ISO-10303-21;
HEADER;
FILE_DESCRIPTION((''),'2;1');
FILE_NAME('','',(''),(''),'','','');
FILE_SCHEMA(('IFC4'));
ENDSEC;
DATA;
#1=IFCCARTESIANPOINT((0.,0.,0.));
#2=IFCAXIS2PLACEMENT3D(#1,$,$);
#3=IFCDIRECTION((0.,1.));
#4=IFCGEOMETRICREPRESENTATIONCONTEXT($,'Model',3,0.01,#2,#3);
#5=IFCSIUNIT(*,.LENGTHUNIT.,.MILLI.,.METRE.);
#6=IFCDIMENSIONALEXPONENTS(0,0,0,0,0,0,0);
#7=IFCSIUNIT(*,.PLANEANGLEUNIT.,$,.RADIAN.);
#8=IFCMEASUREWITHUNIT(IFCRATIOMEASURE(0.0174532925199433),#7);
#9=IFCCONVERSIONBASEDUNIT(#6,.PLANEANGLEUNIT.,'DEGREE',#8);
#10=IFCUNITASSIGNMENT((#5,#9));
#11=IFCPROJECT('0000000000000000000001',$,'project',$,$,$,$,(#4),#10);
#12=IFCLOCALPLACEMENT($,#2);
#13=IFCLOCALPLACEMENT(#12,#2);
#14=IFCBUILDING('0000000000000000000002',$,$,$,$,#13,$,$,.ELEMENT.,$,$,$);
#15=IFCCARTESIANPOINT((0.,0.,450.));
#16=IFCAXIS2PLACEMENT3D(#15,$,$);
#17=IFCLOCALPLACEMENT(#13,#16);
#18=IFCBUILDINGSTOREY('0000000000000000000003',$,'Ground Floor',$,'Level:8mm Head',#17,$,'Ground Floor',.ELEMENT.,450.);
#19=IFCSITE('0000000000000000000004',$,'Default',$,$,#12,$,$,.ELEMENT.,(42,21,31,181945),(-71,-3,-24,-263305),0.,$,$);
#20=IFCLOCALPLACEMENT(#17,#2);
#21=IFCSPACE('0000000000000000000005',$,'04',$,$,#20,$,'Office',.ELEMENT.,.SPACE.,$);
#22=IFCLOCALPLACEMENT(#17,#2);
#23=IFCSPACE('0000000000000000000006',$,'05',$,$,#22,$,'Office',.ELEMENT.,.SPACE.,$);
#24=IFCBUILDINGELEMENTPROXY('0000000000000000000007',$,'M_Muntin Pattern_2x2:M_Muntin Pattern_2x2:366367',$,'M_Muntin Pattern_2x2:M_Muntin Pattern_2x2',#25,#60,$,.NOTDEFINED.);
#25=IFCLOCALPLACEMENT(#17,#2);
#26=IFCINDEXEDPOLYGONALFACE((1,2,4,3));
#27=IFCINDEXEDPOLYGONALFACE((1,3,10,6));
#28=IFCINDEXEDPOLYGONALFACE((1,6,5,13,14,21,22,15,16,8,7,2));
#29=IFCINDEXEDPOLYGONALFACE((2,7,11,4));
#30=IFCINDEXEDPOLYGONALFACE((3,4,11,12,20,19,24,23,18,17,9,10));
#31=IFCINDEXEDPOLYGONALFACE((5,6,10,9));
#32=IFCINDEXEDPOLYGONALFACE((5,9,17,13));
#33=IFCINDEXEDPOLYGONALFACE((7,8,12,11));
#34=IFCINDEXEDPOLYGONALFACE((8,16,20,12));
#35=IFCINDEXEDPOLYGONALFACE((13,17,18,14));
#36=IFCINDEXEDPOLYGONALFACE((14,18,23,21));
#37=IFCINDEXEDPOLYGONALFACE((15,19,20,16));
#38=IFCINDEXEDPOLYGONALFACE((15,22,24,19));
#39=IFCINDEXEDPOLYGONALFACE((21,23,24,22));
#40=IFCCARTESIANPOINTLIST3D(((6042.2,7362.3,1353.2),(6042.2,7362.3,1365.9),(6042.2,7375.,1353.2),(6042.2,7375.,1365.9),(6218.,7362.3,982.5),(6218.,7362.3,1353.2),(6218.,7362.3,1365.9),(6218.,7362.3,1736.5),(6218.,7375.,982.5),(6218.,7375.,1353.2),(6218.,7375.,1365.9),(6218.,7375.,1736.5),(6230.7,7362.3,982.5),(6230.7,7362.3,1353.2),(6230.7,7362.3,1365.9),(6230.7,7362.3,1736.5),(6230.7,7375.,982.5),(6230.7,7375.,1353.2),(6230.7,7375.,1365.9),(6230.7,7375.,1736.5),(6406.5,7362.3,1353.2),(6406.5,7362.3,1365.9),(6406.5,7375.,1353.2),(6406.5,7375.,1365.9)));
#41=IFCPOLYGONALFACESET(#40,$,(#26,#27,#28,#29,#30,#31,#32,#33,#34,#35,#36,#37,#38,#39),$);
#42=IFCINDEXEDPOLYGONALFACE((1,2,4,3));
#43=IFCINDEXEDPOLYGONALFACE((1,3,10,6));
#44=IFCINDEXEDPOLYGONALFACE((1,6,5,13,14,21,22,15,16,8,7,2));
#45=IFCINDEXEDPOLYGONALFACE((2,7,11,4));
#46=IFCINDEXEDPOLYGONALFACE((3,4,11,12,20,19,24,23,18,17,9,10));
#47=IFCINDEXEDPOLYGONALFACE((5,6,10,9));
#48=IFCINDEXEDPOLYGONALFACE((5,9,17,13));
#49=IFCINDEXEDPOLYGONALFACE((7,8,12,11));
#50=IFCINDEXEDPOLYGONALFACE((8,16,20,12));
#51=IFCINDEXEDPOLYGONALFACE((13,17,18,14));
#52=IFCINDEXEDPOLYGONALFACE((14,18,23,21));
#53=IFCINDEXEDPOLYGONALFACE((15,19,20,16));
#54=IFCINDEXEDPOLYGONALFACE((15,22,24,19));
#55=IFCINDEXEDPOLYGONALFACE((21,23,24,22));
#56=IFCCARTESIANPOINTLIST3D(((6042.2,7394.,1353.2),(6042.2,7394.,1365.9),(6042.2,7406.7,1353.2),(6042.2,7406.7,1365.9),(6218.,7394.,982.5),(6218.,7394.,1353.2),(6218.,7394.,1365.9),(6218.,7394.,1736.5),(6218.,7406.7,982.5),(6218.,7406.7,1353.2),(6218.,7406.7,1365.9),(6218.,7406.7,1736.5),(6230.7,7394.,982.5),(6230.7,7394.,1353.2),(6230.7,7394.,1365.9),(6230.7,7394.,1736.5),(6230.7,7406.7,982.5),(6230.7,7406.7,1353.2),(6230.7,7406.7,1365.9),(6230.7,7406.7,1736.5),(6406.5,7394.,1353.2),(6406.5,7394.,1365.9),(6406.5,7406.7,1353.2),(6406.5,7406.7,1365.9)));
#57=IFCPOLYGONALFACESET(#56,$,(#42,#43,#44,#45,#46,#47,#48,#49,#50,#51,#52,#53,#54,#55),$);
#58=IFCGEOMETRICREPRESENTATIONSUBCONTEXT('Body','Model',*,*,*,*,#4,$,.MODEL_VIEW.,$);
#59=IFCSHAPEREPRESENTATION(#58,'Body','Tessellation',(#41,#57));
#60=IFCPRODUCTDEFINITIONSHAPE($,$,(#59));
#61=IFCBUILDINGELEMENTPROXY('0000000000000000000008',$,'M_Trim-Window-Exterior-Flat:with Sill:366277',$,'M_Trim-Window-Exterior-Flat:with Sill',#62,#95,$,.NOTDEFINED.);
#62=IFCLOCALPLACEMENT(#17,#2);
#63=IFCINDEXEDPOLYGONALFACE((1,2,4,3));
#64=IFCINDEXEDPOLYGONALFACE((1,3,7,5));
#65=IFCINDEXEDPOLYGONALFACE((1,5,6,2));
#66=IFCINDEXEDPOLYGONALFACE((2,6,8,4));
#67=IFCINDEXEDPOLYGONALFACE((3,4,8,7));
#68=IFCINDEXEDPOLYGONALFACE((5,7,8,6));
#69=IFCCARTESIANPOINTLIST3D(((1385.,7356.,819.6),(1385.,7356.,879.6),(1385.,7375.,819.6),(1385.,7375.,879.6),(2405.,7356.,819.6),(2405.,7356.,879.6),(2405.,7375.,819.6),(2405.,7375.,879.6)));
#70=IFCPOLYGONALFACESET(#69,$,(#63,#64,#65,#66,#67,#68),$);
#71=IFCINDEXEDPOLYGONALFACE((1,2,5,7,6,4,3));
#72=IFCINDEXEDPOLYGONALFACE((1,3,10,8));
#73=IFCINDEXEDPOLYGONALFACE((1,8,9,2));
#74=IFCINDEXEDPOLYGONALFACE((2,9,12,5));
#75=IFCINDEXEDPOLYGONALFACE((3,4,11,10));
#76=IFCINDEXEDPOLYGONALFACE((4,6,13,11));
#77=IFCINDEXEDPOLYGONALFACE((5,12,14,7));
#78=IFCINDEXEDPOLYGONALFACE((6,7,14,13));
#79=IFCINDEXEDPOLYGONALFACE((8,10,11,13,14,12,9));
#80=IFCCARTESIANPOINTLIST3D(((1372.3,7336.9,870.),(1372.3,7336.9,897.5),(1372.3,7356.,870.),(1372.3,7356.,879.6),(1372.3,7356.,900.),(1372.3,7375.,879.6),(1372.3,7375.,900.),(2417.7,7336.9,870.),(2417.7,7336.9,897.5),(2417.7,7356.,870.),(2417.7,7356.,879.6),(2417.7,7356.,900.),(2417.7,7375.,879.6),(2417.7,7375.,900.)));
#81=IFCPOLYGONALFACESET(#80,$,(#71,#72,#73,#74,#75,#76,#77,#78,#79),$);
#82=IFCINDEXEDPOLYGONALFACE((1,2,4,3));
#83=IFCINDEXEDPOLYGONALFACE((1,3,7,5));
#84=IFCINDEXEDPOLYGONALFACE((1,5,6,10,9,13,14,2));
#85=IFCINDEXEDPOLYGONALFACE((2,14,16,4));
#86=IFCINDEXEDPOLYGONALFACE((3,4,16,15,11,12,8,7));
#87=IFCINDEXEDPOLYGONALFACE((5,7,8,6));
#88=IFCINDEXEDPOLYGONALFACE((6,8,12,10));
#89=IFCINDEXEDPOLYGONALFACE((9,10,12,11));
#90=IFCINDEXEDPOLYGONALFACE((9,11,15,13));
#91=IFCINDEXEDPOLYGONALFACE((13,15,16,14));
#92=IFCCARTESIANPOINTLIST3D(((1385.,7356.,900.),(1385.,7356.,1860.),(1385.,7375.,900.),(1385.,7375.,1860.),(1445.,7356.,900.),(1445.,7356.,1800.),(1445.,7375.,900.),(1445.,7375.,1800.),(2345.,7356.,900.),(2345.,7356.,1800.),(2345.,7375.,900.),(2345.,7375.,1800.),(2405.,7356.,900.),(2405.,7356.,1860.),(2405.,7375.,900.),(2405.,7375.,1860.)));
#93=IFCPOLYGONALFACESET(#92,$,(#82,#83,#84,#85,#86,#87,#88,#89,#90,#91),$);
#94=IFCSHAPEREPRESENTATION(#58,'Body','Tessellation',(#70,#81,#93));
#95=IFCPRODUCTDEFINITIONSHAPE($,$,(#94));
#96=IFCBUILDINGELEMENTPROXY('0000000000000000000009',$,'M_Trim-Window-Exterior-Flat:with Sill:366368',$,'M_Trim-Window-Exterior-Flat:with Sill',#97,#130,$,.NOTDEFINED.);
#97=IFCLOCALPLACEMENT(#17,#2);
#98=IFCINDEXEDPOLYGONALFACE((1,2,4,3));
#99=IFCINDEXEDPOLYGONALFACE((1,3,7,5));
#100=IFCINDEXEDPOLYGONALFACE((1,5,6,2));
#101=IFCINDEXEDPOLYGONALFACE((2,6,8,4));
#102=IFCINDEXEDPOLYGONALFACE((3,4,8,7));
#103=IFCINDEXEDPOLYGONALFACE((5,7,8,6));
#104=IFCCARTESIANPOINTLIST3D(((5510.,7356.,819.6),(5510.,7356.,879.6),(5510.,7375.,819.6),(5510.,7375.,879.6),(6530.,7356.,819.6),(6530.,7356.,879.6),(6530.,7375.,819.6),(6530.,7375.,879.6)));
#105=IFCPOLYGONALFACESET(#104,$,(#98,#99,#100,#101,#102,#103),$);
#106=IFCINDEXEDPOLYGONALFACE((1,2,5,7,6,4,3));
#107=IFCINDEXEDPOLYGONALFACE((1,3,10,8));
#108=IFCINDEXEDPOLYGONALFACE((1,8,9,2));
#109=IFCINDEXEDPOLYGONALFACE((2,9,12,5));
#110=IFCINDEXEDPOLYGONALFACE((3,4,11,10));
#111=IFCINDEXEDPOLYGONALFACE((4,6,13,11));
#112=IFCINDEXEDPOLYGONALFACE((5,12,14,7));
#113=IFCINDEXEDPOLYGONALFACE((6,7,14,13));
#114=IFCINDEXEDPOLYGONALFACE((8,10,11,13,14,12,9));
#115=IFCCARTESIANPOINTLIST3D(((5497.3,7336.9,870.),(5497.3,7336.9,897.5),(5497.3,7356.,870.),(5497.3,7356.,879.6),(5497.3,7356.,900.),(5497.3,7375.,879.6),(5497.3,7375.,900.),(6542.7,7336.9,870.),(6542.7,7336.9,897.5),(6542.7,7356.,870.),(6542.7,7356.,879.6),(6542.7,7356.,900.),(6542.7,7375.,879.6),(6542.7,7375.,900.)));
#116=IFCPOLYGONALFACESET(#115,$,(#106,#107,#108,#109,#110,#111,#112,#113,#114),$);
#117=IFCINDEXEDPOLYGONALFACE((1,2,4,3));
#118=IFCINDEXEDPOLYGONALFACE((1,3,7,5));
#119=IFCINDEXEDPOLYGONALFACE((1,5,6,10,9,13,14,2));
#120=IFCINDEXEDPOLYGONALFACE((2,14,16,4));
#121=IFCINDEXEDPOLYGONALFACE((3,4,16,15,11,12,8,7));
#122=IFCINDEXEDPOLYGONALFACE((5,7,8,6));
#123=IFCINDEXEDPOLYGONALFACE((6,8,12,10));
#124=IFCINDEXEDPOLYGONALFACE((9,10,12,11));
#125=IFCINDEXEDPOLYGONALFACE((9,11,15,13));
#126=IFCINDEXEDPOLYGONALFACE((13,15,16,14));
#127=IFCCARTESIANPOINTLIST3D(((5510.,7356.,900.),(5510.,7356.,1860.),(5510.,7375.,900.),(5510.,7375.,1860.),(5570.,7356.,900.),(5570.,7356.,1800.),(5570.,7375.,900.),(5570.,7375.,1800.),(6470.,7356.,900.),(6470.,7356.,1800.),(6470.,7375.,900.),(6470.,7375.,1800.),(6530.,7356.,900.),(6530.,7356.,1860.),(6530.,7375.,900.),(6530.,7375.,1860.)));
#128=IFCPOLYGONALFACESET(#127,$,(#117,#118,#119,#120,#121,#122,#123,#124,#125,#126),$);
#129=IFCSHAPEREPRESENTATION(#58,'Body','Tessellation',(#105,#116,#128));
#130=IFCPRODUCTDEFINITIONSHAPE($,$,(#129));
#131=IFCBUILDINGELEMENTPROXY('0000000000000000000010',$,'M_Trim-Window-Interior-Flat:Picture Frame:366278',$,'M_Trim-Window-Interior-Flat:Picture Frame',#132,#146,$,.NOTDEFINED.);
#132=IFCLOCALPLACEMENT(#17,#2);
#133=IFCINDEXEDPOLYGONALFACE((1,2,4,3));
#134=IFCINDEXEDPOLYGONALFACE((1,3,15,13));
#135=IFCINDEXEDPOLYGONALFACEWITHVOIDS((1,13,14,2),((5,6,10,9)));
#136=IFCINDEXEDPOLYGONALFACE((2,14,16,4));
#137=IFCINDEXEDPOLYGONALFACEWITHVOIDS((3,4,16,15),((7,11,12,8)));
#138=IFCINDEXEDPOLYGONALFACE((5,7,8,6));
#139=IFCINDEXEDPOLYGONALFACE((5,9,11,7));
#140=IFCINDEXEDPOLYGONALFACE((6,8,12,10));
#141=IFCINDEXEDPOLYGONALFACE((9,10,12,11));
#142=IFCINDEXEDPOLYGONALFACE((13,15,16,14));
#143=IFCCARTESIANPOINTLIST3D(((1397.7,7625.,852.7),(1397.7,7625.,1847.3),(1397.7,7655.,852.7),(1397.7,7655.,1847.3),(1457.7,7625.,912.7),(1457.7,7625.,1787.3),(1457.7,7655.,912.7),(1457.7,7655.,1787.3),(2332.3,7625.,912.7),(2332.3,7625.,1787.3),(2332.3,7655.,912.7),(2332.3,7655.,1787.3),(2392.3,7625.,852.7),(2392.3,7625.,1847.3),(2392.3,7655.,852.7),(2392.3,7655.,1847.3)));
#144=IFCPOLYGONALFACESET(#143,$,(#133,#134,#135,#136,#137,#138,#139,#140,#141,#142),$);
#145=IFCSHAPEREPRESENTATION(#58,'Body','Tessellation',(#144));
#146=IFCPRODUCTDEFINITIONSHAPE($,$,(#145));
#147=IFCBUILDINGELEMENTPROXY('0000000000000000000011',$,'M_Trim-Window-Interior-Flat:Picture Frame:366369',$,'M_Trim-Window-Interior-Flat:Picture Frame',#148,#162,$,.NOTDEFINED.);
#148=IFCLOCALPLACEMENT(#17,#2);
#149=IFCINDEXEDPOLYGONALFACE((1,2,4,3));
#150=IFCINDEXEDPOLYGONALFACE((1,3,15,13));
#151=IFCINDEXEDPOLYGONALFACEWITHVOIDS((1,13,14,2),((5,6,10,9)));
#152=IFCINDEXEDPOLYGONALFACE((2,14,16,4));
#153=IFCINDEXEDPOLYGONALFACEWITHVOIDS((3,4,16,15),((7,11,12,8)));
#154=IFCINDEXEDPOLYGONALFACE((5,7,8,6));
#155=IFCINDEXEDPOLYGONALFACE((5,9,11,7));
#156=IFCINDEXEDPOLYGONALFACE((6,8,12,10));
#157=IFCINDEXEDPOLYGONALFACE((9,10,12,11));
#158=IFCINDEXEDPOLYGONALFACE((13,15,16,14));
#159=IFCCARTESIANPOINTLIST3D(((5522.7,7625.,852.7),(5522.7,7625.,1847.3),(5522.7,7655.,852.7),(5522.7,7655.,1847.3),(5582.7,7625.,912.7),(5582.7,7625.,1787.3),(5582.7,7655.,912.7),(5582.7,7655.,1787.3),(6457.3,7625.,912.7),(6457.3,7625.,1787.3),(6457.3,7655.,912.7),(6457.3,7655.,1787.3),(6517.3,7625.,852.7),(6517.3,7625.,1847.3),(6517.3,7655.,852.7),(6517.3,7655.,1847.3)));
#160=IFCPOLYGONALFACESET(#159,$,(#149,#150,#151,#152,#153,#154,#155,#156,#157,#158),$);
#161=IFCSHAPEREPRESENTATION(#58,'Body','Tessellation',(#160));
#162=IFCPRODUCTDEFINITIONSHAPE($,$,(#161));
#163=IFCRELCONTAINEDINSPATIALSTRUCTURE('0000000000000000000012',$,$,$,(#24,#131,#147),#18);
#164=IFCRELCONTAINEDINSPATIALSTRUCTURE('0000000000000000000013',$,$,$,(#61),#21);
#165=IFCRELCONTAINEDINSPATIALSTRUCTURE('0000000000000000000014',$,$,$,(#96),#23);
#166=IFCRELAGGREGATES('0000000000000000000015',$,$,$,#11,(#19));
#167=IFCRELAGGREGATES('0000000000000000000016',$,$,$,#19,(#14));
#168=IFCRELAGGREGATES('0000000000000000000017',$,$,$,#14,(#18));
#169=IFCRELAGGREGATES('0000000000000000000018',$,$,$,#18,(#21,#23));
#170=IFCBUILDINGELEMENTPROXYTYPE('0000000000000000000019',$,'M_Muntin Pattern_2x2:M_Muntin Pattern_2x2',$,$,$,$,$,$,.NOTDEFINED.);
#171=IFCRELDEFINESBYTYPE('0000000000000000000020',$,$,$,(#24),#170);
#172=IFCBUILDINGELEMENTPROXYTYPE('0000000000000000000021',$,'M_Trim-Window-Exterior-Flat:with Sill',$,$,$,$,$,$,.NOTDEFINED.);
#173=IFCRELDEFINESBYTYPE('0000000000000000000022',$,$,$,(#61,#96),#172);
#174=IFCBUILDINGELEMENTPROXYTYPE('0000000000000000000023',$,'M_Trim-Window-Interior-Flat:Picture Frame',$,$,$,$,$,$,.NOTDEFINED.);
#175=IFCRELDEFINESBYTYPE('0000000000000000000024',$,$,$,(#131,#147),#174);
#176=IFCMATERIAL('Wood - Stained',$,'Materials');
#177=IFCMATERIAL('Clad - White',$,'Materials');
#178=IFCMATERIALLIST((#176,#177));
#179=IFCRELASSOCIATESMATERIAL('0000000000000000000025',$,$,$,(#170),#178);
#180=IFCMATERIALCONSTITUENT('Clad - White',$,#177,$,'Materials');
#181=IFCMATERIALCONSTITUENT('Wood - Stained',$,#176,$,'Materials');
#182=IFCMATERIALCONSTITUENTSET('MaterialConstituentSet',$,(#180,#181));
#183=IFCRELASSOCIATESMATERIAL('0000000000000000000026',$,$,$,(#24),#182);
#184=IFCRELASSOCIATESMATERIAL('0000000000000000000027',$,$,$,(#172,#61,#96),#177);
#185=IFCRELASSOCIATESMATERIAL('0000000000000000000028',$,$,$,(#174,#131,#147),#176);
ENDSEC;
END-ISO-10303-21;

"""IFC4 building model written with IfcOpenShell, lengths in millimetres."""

from ifc_helpers import new_model, entity, si_unit, converted_unit, direction, frame, frame_2d, origin, place, context, subcontext, project, spatial, polyline, rectangle, outline, extrude, source, transform, mapped, material, material_list, constituent, constituent_set, type_object, type_shapes, element, save


model = new_model("IFC4")

# Units and contexts
model_context = context("Model", 3, precision=0.01, world=origin(), true_north=direction((0.0, 1.0)))
body_context = subcontext(model_context, "Body", "Model", "MODEL_VIEW")
ifc_project = project(units=[si_unit("LENGTHUNIT", "METRE", prefix="MILLI"), converted_unit("PLANEANGLEUNIT", "DEGREE", entity("IfcRatioMeasure", 0.0174532925199433), si_unit("PLANEANGLEUNIT", "RADIAN"), dimensions=[0, 0, 0, 0, 0, 0, 0])], contexts=[model_context])

# Site, building, storey
site_placement = place(None, origin())
site = spatial("IfcSite", under=ifc_project, at=site_placement, Name="Default", CompositionType="ELEMENT", RefLatitude=(42, 21, 31, 181945), RefLongitude=(-71, -3, -24, -263305), RefElevation=0.0)
building_placement = place(site_placement, origin())
building = spatial("IfcBuilding", under=site, at=building_placement, CompositionType="ELEMENT")
storey_placement = place(building_placement, frame((0.0, 0.0, 450.0)))
storey = spatial("IfcBuildingStorey", under=building, at=storey_placement, Name="Ground Floor", ObjectType="Level:8mm Head", LongName="Ground Floor", CompositionType="ELEMENT", Elevation=450.0)

# Shared definitions
space_1_placement = place(storey_placement, origin())
space_1 = spatial("IfcSpace", under=storey, at=space_1_placement, Name="04", LongName="Office", CompositionType="ELEMENT", PredefinedType="SPACE")

# Building element proxies
ifc_material_1 = material(Name="Clad - White", Category="Materials")
ifc_material_2 = material(Name="Wood - Stained", Category="Materials")
ifc_material_list_1 = material_list([ifc_material_2, ifc_material_1])
building_element_proxy_type_1 = type_object("IfcBuildingElementProxyType", Name="M_Muntin Pattern_2x2:M_Muntin Pattern_2x2", PredefinedType="NOTDEFINED", material=ifc_material_list_1)
shared_shape_1 = source(origin(), body_context, "Body", "SweptSolid", [
    extrude(outline(polyline([(6.4, -6.4), (377.0, -6.4), (377.0, 6.3), (6.4, 6.3), (6.4, 182.1), (-6.3, 182.1), (-6.3, 6.3), (-377.0, 6.3), (-377.0, -6.4), (-6.3, -6.4), (-6.3, -182.1), (6.4, -182.1), (6.4, -6.4)])), frame((0.0, 9.5, 377.0), z_axis=(0.0, 1.0, 0.0), x_axis=(0.0, 0.0, 1.0)), (0.0, 0.0, 1.0), 12.7),
    extrude(outline(polyline([(6.4, -6.4), (377.0, -6.4), (377.0, 6.3), (6.4, 6.3), (6.4, 182.1), (-6.3, 182.1), (-6.3, 6.3), (-377.0, 6.3), (-377.0, -6.4), (-6.3, -6.4), (-6.3, -182.1), (6.4, -182.1), (6.4, -6.4)])), frame((0.0, -22.2, 377.0), z_axis=(0.0, 1.0, 0.0), x_axis=(0.0, 0.0, 1.0)), (0.0, 0.0, 1.0), 12.7),
])
type_shapes(building_element_proxy_type_1, [shared_shape_1])
ifc_constituent_1 = constituent(ifc_material_1, Name="Clad - White", Category="Materials")
ifc_constituent_2 = constituent(ifc_material_2, Name="Wood - Stained", Category="Materials")
ifc_constituent_set_1 = constituent_set(constituents=[ifc_constituent_1, ifc_constituent_2], Name="MaterialConstituentSet")
proxy_1_placement = place(storey_placement, frame((6224.4, 7384.5, 982.5), z_axis=(0.0, 0.0, 1.0), x_axis=(-1.0, 0.0, 0.0)))
element("IfcBuildingElementProxy", 1, at=proxy_1_placement, inside=storey, type_object=building_element_proxy_type_1, material=ifc_constituent_set_1, Name="M_Muntin Pattern_2x2:M_Muntin Pattern_2x2:366367", ObjectType="M_Muntin Pattern_2x2:M_Muntin Pattern_2x2", PredefinedType="NOTDEFINED", context=body_context, shape_type="MappedRepresentation", body=[
    mapped(shared_shape_1, transform((0.0, 0.0, 0.0), scale=1.0)),
])
building_element_proxy_type_2 = type_object("IfcBuildingElementProxyType", Name="M_Trim-Window-Exterior-Flat:with Sill", PredefinedType="NOTDEFINED", material=ifc_material_1)
shared_shape_2 = source(origin(), body_context, "Body", "SweptSolid", [
    extrude(rectangle(XDim=1020.0, YDim=60.0, at=frame_2d((0.0, 0.0), x_axis=(1.0, 0.0))), frame((0.0, -950.4, 0.0), z_axis=(0.0, 0.0, 1.0), x_axis=(-1.0, 0.0, 0.0)), (0.0, 0.0, 1.0), 19.1),
    extrude(outline(polyline([(-19.0, -15.2), (0.0, -15.2), (0.0, -5.7), (19.0, -5.7), (19.0, 14.8), (0.0, 14.8), (-19.0, 12.3), (-19.0, -15.2)])), frame((-522.7, -914.8, 19.0), z_axis=(1.0, 0.0, 0.0), x_axis=(0.0, 0.0, -1.0)), (0.0, 0.0, 1.0), 1045.4),
    extrude(outline(polyline([(-495.0, -510.0), (465.0, -510.0), (465.0, -450.0), (-435.0, -450.0), (-435.0, 450.0), (465.0, 450.0), (465.0, 510.0), (-495.0, 510.0), (-495.0, -510.0)])), frame((0.0, -435.0, 0.0), z_axis=(0.0, 0.0, 1.0), x_axis=(0.0, -1.0, 0.0)), (0.0, 0.0, 1.0), 19.1),
])
type_shapes(building_element_proxy_type_2, [shared_shape_2])
proxy_2_placement = place(space_1_placement, frame((1895.0, 7375.0, 1800.0), z_axis=(0.0, -1.0, 0.0), x_axis=(1.0, 0.0, 0.0)))
element("IfcBuildingElementProxy", 2, at=proxy_2_placement, inside=space_1, type_object=building_element_proxy_type_2, material=ifc_material_1, Name="M_Trim-Window-Exterior-Flat:with Sill:366277", ObjectType="M_Trim-Window-Exterior-Flat:with Sill", PredefinedType="NOTDEFINED", context=body_context, shape_type="MappedRepresentation", body=[
    mapped(shared_shape_2, transform((0.0, 0.0, 0.0), scale=1.0)),
])

# Shared definitions
space_2_placement = place(storey_placement, origin())
space_2 = spatial("IfcSpace", under=storey, at=space_2_placement, Name="05", LongName="Office", CompositionType="ELEMENT", PredefinedType="SPACE")

# Building element proxies
proxy_3_placement = place(space_2_placement, frame((6020.0, 7375.0, 1800.0), z_axis=(0.0, -1.0, 0.0), x_axis=(1.0, 0.0, 0.0)))
element("IfcBuildingElementProxy", 3, at=proxy_3_placement, inside=space_2, type_object=building_element_proxy_type_2, material=ifc_material_1, Name="M_Trim-Window-Exterior-Flat:with Sill:366368", ObjectType="M_Trim-Window-Exterior-Flat:with Sill", PredefinedType="NOTDEFINED", context=body_context, shape_type="MappedRepresentation", body=[
    mapped(shared_shape_2, transform((0.0, 0.0, 0.0), scale=1.0)),
])
building_element_proxy_type_3 = type_object("IfcBuildingElementProxyType", Name="M_Trim-Window-Interior-Flat:Picture Frame", PredefinedType="NOTDEFINED", material=ifc_material_2)
shared_shape_3 = source(origin(), body_context, "Body", "SweptSolid", [
    extrude(outline(polyline([(-497.3, -497.3), (497.3, -497.3), (497.3, 497.3), (-497.3, 497.3), (-497.3, -497.3)]), holes=[polyline([(-437.3, -437.3), (-437.3, 437.3), (437.3, 437.3), (437.3, -437.3), (-437.3, -437.3)])]), frame((0.0, -450.0, 0.0), z_axis=(0.0, 0.0, 1.0), x_axis=(-1.0, 0.0, 0.0)), (0.0, 0.0, 1.0), 30.0),
])
type_shapes(building_element_proxy_type_3, [shared_shape_3])
for number, where, z_axis, x_axis, name in (
    (4, (1895.0, 7625.0, 1800.0), (0.0, 1.0, 0.0), (-1.0, 0.0, 0.0), "M_Trim-Window-Interior-Flat:Picture Frame:366278"),
    (5, (6020.0, 7625.0, 1800.0), (0.0, 1.0, 0.0), (-1.0, 0.0, 0.0), "M_Trim-Window-Interior-Flat:Picture Frame:366369"),
):
    element("IfcBuildingElementProxy", number, at=place(storey_placement, frame(where, z_axis=z_axis, x_axis=x_axis)), inside=storey, type_object=building_element_proxy_type_3, material=ifc_material_2, Name=name, ObjectType="M_Trim-Window-Interior-Flat:Picture Frame", PredefinedType="NOTDEFINED", context=body_context, shape_type="MappedRepresentation", body=[
        mapped(shared_shape_3, transform((0.0, 0.0, 0.0), scale=1.0)),
    ])

save(model, "model.ifc")
